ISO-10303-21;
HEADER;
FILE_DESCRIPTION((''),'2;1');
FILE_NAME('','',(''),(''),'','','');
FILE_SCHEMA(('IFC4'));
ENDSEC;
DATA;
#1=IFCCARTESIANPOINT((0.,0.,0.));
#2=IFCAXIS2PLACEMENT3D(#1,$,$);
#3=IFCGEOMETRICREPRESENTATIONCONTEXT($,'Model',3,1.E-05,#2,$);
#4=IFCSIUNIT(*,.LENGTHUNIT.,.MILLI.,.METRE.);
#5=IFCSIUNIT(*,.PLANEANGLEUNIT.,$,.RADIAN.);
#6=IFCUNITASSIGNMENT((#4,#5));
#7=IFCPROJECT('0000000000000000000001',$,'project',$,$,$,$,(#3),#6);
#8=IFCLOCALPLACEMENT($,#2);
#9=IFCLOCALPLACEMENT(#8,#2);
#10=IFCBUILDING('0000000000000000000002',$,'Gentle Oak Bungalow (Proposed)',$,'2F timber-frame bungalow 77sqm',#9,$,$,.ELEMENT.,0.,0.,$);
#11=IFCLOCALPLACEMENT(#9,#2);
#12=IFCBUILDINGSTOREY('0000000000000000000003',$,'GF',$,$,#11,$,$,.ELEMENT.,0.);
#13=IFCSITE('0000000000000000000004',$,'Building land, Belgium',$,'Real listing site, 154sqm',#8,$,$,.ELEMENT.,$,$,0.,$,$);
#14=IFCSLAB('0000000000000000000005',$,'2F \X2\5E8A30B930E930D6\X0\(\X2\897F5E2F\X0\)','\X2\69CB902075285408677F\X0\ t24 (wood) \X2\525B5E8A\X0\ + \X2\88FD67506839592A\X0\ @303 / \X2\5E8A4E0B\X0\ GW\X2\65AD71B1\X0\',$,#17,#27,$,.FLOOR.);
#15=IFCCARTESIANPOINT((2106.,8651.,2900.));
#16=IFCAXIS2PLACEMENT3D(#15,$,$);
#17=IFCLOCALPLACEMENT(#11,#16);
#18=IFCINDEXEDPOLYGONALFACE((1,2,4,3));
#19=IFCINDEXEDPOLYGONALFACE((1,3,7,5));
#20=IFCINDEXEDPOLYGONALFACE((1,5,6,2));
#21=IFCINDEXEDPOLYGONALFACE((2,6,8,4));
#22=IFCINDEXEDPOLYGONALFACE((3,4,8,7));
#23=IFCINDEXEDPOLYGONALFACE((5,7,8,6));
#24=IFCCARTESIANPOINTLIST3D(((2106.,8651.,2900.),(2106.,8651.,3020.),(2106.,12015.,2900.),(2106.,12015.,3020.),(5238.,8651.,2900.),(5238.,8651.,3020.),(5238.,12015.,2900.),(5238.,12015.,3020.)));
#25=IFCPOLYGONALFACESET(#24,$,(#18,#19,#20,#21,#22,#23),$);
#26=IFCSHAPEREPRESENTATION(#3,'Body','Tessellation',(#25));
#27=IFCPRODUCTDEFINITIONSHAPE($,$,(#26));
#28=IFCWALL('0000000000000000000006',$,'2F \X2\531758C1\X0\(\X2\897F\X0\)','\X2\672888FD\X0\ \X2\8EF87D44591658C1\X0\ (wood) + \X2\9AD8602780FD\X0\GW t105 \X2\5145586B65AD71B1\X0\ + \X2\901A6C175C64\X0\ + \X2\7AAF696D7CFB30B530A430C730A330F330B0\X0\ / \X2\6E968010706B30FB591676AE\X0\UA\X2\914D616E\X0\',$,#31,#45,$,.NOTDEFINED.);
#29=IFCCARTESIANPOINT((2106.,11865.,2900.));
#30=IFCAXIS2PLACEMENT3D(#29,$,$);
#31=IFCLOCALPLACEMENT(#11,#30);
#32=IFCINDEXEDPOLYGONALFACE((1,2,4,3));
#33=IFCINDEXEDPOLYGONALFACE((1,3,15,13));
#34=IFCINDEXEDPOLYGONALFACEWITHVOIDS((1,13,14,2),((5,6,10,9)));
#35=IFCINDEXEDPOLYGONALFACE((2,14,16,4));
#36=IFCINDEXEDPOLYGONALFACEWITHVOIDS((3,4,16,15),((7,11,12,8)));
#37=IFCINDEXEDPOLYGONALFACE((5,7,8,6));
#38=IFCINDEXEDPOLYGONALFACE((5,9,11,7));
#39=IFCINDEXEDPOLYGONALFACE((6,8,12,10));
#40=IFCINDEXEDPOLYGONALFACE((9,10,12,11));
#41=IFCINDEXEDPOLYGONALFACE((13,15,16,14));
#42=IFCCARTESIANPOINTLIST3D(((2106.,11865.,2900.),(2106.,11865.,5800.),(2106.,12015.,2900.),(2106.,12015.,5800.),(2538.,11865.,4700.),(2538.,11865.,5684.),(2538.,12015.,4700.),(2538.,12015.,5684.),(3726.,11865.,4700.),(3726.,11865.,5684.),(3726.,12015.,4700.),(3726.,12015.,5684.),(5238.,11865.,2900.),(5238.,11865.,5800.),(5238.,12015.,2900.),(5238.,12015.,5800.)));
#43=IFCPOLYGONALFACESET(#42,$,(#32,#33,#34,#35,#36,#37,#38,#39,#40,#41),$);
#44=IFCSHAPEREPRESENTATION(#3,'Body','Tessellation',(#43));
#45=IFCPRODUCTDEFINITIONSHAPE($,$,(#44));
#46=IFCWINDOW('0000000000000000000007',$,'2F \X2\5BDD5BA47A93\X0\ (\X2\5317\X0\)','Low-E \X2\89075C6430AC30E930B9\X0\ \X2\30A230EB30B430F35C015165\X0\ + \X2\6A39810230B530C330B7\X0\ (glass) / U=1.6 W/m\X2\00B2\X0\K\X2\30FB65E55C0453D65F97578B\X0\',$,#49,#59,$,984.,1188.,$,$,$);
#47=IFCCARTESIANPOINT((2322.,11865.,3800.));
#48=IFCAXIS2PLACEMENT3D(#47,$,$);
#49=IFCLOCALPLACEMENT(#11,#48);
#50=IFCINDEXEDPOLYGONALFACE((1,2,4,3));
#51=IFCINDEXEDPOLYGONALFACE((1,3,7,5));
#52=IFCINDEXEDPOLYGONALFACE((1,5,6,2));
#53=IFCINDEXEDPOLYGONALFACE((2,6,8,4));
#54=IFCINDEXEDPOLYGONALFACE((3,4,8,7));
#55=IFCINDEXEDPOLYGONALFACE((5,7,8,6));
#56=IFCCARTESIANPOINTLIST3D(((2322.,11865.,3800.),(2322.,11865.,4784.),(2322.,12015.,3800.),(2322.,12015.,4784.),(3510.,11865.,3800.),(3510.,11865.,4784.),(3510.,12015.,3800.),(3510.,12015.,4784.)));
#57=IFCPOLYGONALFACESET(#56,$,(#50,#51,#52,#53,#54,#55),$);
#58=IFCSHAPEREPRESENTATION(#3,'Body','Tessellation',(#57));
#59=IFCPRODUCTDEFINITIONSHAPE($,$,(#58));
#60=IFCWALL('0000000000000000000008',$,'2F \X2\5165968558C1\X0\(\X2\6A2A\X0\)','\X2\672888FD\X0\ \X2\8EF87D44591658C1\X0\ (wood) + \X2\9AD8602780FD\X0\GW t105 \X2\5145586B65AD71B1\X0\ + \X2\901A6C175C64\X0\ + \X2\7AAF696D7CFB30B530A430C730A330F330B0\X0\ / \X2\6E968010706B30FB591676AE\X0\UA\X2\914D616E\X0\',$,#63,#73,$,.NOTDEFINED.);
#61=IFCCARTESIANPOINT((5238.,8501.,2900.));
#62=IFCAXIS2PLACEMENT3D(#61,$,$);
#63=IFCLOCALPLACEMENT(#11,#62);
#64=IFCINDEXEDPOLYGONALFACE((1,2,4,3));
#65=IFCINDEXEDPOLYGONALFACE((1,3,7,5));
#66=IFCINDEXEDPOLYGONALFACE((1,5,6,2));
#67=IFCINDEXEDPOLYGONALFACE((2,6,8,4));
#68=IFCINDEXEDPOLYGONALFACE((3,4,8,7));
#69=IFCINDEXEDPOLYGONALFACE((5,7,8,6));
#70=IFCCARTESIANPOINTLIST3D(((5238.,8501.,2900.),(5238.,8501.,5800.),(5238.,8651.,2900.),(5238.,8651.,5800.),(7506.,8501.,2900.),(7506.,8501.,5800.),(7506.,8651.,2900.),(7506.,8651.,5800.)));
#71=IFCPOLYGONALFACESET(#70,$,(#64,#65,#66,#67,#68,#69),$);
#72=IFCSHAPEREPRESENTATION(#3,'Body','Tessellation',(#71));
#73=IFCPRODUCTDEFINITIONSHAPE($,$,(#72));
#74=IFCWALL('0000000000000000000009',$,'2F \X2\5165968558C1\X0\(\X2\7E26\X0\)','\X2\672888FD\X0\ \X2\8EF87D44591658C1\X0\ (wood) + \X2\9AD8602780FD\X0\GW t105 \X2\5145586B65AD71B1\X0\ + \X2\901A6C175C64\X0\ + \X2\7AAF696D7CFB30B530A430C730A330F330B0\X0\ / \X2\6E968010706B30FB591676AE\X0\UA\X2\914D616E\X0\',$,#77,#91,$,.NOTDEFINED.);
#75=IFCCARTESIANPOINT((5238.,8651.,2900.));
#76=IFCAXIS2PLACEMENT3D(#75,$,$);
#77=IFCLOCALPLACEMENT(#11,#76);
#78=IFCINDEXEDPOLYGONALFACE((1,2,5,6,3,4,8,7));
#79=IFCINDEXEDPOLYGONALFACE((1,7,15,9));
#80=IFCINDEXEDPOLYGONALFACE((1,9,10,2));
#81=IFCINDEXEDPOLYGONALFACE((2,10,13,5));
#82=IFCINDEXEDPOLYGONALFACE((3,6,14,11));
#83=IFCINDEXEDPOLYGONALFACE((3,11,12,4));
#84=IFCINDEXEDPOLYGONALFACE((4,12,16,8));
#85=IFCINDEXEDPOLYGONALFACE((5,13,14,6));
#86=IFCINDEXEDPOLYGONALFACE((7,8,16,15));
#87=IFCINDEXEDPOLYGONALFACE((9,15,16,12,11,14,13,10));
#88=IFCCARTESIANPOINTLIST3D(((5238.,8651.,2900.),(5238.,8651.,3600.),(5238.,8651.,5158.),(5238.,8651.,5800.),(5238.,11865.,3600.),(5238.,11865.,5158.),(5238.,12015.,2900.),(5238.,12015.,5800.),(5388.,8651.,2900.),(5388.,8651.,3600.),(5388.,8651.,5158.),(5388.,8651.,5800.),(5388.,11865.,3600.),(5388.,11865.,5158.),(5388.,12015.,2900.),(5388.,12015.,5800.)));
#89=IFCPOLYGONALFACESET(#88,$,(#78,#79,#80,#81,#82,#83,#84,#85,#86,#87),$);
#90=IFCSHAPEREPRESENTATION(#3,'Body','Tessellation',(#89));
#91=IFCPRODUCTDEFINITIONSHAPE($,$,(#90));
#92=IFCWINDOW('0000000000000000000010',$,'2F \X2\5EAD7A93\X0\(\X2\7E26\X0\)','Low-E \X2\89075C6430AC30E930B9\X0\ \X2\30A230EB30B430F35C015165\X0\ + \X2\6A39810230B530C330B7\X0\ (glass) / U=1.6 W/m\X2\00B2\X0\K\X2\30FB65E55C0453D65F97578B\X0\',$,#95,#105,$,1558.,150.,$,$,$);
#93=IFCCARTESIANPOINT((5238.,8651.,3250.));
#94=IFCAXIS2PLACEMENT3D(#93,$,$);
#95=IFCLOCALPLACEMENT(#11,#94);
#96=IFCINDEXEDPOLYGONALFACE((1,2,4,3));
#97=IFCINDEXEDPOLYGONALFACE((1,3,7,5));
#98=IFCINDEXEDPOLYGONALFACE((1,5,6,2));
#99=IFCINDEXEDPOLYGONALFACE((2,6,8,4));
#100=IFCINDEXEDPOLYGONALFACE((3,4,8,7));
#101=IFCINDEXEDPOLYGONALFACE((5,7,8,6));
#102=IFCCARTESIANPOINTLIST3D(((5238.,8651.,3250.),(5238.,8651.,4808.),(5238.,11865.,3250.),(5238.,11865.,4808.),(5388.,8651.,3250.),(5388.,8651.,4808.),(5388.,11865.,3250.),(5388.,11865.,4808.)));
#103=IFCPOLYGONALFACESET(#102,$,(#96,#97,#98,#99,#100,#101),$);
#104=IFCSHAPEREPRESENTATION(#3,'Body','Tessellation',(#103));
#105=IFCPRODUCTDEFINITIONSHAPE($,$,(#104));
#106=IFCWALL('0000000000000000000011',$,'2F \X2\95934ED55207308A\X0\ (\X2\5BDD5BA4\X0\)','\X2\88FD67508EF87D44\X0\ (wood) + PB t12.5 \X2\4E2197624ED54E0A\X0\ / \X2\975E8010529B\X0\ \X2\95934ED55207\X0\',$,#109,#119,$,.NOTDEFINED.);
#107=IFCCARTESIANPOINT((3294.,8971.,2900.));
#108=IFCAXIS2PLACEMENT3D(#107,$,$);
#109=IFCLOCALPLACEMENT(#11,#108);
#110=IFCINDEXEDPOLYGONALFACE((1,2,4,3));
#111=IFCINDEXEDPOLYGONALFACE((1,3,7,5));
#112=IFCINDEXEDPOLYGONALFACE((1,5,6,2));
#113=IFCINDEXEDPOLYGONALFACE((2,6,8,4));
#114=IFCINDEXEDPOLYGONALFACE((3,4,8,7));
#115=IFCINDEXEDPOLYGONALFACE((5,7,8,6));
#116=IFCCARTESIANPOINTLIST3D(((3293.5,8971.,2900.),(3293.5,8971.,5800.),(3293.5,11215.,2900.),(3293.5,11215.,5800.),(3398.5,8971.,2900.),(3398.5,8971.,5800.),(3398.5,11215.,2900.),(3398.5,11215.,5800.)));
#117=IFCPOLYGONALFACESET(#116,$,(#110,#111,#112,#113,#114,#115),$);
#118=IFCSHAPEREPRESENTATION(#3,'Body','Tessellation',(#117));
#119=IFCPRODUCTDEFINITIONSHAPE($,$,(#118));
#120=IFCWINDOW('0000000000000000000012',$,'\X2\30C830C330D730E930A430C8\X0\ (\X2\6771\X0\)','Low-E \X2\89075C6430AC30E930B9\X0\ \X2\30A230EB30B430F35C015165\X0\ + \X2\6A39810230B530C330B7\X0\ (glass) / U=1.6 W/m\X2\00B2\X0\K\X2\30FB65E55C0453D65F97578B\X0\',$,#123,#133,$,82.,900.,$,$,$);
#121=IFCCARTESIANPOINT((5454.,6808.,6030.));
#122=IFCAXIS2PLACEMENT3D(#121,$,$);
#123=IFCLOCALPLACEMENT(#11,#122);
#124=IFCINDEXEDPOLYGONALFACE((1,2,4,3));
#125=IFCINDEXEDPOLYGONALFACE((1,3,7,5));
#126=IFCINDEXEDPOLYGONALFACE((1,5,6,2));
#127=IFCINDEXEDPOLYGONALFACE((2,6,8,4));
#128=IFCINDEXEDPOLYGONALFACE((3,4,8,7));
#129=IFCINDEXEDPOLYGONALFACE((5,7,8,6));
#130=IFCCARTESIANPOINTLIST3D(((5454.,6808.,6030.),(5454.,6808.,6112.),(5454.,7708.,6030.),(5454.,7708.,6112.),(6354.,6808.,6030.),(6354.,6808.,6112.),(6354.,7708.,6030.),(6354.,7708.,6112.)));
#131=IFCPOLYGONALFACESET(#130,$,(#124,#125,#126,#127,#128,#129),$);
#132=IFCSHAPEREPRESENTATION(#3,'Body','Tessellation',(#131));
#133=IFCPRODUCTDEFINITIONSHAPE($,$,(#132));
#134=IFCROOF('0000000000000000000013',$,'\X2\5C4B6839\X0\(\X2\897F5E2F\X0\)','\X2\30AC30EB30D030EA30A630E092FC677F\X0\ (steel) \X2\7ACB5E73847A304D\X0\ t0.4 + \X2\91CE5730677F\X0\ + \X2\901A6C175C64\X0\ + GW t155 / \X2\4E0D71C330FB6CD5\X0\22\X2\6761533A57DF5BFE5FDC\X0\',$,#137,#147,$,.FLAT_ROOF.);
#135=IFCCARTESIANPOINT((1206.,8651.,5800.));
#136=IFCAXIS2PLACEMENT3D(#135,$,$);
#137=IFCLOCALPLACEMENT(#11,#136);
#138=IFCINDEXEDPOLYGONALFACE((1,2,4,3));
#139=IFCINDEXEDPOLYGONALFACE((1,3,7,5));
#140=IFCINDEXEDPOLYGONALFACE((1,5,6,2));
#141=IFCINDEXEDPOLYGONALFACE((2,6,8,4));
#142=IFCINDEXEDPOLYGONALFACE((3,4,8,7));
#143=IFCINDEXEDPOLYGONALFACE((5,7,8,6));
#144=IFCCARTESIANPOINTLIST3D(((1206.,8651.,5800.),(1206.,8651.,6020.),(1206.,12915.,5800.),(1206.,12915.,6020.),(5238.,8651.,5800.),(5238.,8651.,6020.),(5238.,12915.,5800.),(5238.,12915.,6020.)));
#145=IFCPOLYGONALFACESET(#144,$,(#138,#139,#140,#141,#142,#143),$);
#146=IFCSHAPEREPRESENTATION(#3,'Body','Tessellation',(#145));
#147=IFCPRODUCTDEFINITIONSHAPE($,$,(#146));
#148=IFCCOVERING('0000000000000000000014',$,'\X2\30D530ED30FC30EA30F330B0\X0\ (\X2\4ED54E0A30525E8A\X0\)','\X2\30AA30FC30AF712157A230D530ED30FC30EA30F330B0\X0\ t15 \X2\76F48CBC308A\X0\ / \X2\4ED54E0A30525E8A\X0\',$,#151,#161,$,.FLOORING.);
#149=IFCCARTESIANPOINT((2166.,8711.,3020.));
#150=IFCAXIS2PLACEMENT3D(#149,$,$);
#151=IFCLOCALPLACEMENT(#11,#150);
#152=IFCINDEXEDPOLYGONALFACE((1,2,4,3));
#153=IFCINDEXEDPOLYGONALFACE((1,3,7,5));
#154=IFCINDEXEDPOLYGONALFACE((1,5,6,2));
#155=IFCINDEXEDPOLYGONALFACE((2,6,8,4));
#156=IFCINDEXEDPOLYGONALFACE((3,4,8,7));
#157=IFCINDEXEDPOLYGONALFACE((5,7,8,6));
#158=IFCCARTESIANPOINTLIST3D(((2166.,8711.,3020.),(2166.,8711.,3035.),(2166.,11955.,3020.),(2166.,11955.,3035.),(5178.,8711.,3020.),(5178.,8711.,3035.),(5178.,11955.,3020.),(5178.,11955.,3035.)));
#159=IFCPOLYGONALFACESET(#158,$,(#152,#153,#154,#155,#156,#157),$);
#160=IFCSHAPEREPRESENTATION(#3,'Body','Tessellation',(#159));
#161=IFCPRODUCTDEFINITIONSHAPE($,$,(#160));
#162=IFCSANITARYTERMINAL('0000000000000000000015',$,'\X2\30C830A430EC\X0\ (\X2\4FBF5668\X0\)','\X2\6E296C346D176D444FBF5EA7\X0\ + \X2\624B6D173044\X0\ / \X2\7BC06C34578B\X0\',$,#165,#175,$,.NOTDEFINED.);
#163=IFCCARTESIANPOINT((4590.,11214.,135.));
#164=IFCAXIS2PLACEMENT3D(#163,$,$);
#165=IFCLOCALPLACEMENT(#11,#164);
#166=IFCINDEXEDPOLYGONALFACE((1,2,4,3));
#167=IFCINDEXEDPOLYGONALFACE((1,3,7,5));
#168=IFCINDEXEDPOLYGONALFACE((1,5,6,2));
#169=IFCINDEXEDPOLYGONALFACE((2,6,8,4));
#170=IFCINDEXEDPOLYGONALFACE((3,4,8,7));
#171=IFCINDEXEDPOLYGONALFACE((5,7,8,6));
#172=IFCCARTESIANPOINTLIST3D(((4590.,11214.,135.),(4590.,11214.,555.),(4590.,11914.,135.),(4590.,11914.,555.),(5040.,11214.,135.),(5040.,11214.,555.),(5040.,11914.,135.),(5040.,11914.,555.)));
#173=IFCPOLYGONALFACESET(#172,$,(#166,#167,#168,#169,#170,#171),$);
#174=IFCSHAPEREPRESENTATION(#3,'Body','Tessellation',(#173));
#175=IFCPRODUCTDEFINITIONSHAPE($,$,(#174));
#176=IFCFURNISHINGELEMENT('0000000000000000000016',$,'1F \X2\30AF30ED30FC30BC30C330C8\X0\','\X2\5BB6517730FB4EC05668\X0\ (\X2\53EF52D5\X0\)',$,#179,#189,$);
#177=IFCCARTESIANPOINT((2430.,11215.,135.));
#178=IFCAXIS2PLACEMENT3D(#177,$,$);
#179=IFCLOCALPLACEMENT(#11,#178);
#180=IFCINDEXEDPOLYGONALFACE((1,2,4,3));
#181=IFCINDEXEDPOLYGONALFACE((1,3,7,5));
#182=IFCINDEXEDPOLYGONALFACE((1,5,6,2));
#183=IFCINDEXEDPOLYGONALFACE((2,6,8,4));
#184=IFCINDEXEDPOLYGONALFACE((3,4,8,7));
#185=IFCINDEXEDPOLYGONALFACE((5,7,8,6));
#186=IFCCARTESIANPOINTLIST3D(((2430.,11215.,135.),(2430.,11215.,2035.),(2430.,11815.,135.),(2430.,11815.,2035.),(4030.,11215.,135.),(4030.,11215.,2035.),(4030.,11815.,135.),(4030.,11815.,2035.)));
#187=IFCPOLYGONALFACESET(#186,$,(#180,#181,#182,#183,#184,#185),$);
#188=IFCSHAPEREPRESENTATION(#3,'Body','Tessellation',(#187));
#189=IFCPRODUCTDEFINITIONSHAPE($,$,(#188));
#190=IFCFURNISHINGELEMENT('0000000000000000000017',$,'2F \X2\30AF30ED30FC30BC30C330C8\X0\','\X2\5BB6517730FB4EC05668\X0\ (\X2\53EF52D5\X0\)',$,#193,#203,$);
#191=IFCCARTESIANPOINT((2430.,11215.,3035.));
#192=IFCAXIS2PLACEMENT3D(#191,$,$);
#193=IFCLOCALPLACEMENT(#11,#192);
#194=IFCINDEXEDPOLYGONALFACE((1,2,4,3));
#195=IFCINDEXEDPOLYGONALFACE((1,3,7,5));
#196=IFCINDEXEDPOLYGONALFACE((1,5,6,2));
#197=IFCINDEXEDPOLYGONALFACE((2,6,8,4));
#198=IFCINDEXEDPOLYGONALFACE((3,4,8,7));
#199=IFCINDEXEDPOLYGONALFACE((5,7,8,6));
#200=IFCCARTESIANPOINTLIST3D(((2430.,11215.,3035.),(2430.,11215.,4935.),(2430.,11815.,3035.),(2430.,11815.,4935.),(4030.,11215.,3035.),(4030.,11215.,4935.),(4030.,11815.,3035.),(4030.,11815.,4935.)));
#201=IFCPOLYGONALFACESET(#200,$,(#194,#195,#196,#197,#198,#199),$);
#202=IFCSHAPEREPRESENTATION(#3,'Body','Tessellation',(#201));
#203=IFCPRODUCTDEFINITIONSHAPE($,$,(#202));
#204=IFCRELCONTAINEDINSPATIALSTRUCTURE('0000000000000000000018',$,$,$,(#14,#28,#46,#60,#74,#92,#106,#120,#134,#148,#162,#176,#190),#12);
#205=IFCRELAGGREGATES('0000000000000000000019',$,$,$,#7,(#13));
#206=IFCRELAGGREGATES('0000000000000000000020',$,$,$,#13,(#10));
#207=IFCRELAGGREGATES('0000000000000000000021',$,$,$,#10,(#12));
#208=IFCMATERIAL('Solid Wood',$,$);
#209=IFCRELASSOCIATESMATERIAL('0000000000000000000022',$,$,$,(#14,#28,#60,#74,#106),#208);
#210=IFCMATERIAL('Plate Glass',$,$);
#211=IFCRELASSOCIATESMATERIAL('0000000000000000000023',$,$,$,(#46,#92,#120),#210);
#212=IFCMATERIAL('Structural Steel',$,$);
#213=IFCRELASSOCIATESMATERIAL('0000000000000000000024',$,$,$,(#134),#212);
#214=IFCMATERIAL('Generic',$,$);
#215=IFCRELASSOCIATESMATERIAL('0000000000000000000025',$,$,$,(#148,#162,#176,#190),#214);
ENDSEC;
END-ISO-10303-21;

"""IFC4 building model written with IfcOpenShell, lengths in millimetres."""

from ifc_helpers import new_model, si_unit, frame, frame_2d, origin, place, context, project, spatial, rectangle, extrude, material, element, fill, save


model = new_model("IFC4")

# Units and contexts
model_context = context("Model", 3, precision=1e-05, world=origin())
ifc_project = project(units=[si_unit("LENGTHUNIT", "METRE", prefix="MILLI"), si_unit("PLANEANGLEUNIT", "RADIAN")], contexts=[model_context])

# Site, building, storey
site_placement = place(None, origin())
site = spatial("IfcSite", under=ifc_project, at=site_placement, Name="Building land, Belgium", ObjectType="Real listing site, 154sqm", CompositionType="ELEMENT", RefElevation=0.0)
building_placement = place(site_placement, origin())
building = spatial("IfcBuilding", under=site, at=building_placement, Name="Gentle Oak Bungalow (Proposed)", ObjectType="2F timber-frame bungalow 77sqm", CompositionType="ELEMENT", ElevationOfRefHeight=0.0, ElevationOfTerrain=0.0)
storey_placement = place(building_placement, origin())
storey = spatial("IfcBuildingStorey", under=building, at=storey_placement, Name="GF", CompositionType="ELEMENT", Elevation=0.0)

# Slab
ifc_material_1 = material(Name="Solid Wood")
slab_placement = place(storey_placement, frame((2106.0, 8651.0, 2900.0)))
element("IfcSlab", 1, at=slab_placement, inside=storey, material=ifc_material_1, Name="2F 床スラブ(西帯)", Description="構造用合板 t24 (wood) 剛床 + 製材根太 @303 / 床下 GW断熱", PredefinedType="FLOOR", context=model_context, shape_type="SweptSolid", body=[
    extrude(rectangle(XDim=3132.0, YDim=3364.0, at=frame_2d((1566.0, 1682.0))), frame((2106.0, 8651.0, 2900.0)), (0.0, 0.0, 1.0), 120.0),
])

# Wall, opening, window
wall_1_placement = place(storey_placement, frame((2106.0, 11865.0, 2900.0)))
wall_1 = element("IfcWall", 2, at=wall_1_placement, inside=storey, material=ifc_material_1, Name="2F 北壁(西)", Description="木製 軸組外壁 (wood) + 高性能GW t105 充填断熱 + 通気層 + 窯業系サイディング / 準耐火・外皮UA配慮", PredefinedType="NOTDEFINED", context=model_context, shape_type="SweptSolid", body=[
    extrude(rectangle(XDim=3132.0, YDim=150.0, at=frame_2d((1566.0, 75.0))), frame((2106.0, 11865.0, 2900.0)), (0.0, 0.0, 1.0), 2900.0),
])
opening_1_placement = place(storey_placement, frame((2322.0, 11865.0, 3800.0)))
opening_1 = element("IfcOpeningElement", 3, at=opening_1_placement, cuts=wall_1, PredefinedType="NOTDEFINED", context=model_context, shape_type="SweptSolid", body=[
    extrude(rectangle(XDim=1188.0, YDim=150.0, at=frame_2d((594.0, 75.0))), frame((2322.0, 11865.0, 3800.0)), (0.0, 0.0, 1.0), 984.0),
])
ifc_material_2 = material(Name="Plate Glass")
window_1_placement = place(storey_placement, frame((2322.0, 11865.0, 3800.0)))
window_1 = element("IfcWindow", 4, at=window_1_placement, inside=storey, material=ifc_material_2, Name="2F 寝室窓 (北)", Description="Low-E 複層ガラス アルゴン封入 + 樹脂サッシ (glass) / U=1.6 W/m²K・日射取得型", OverallHeight=984.0, OverallWidth=1188.0, context=model_context, shape_type="SweptSolid", body=[
    extrude(rectangle(XDim=1188.0, YDim=150.0, at=frame_2d((594.0, 75.0))), frame((2322.0, 11865.0, 3800.0)), (0.0, 0.0, 1.0), 984.0),
])
fill(opening_1, window_1)

# Wall
wall_2_placement = place(storey_placement, frame((5238.0, 8501.0, 2900.0)))
element("IfcWall", 5, at=wall_2_placement, inside=storey, material=ifc_material_1, Name="2F 入隅壁(横)", Description="木製 軸組外壁 (wood) + 高性能GW t105 充填断熱 + 通気層 + 窯業系サイディング / 準耐火・外皮UA配慮", PredefinedType="NOTDEFINED", context=model_context, shape_type="SweptSolid", body=[
    extrude(rectangle(XDim=2268.0, YDim=150.0, at=frame_2d((1134.0, 75.0))), frame((5238.0, 8501.0, 2900.0)), (0.0, 0.0, 1.0), 2900.0),
])

# Wall, opening, window
wall_3_placement = place(storey_placement, frame((5238.0, 8651.0, 2900.0)))
wall_3 = element("IfcWall", 6, at=wall_3_placement, inside=storey, material=ifc_material_1, Name="2F 入隅壁(縦)", Description="木製 軸組外壁 (wood) + 高性能GW t105 充填断熱 + 通気層 + 窯業系サイディング / 準耐火・外皮UA配慮", PredefinedType="NOTDEFINED", context=model_context, shape_type="SweptSolid", body=[
    extrude(rectangle(XDim=150.0, YDim=3364.0, at=frame_2d((75.0, 1682.0))), frame((5238.0, 8651.0, 2900.0)), (0.0, 0.0, 1.0), 2900.0),
])
opening_2_placement = place(storey_placement, frame((5238.0, 8651.0, 3250.0)))
opening_2 = element("IfcOpeningElement", 7, at=opening_2_placement, cuts=wall_3, PredefinedType="NOTDEFINED", context=model_context, shape_type="SweptSolid", body=[
    extrude(rectangle(XDim=150.0, YDim=3214.0, at=frame_2d((75.0, 1607.0))), frame((5238.0, 8651.0, 3250.0)), (0.0, 0.0, 1.0), 1558.0),
])
window_2_placement = place(storey_placement, frame((5238.0, 8651.0, 3250.0)))
window_2 = element("IfcWindow", 8, at=window_2_placement, inside=storey, material=ifc_material_2, Name="2F 庭窓(縦)", Description="Low-E 複層ガラス アルゴン封入 + 樹脂サッシ (glass) / U=1.6 W/m²K・日射取得型", OverallHeight=1558.0, OverallWidth=150.0, context=model_context, shape_type="SweptSolid", body=[
    extrude(rectangle(XDim=150.0, YDim=3214.0, at=frame_2d((75.0, 1607.0))), frame((5238.0, 8651.0, 3250.0)), (0.0, 0.0, 1.0), 1558.0),
])
fill(opening_2, window_2)

# Wall
wall_4_placement = place(storey_placement, frame((3294.0, 8971.0, 2900.0)))
element("IfcWall", 9, at=wall_4_placement, inside=storey, material=ifc_material_1, Name="2F 間仕切り (寝室)", Description="製材軸組 (wood) + PB t12.5 両面仕上 / 非耐力 間仕切", PredefinedType="NOTDEFINED", context=model_context, shape_type="SweptSolid", body=[
    extrude(rectangle(XDim=105.0, YDim=2244.0, at=frame_2d((52.0, 1122.0))), frame((3294.0, 8971.0, 2900.0)), (0.0, 0.0, 1.0), 2900.0),
])

# Window
window_3_placement = place(storey_placement, frame((5454.0, 6808.0, 6030.0)))
element("IfcWindow", 10, at=window_3_placement, inside=storey, material=ifc_material_2, Name="トップライト (東)", Description="Low-E 複層ガラス アルゴン封入 + 樹脂サッシ (glass) / U=1.6 W/m²K・日射取得型", OverallHeight=82.0, OverallWidth=900.0, context=model_context, shape_type="SweptSolid", body=[
    extrude(rectangle(XDim=900.0, YDim=900.0, at=frame_2d((450.0, 450.0))), frame((5454.0, 6808.0, 6030.0)), (0.0, 0.0, 1.0), 82.0),
])

# Roof
ifc_material_3 = material(Name="Structural Steel")
for number, where, name in (
    (11, (1206.0, 8651.0, 5800.0), "屋根(西帯)"),
):
    element("IfcRoof", number, at=place(storey_placement, frame(where)), inside=storey, material=ifc_material_3, Name=name, Description="ガルバリウム鋼板 (steel) 立平葺き t0.4 + 野地板 + 通気層 + GW t155 / 不燃・法22条区域対応", PredefinedType="FLAT_ROOF", context=model_context, shape_type="SweptSolid", body=[
        extrude(rectangle(XDim=4032.0, YDim=4264.0, at=frame_2d((2016.0, 2132.0))), frame((1206.0, 8651.0, 5800.0)), (0.0, 0.0, 1.0), 220.0),
    ])

# Covering
ifc_material_4 = material(Name="Generic")
covering_placement = place(storey_placement, frame((2166.0, 8711.0, 3020.0)))
element("IfcCovering", 12, at=covering_placement, inside=storey, material=ifc_material_4, Name="フローリング (仕上げ床)", Description="オーク無垢フローリング t15 直貼り / 仕上げ床", PredefinedType="FLOORING", context=model_context, shape_type="SweptSolid", body=[
    extrude(rectangle(XDim=3012.0, YDim=3244.0, at=frame_2d((1506.0, 1622.0))), frame((2166.0, 8711.0, 3020.0)), (0.0, 0.0, 1.0), 15.0),
])

# Sanitary terminal
sanitary_terminal_placement = place(storey_placement, frame((4590.0, 11214.0, 135.0)))
element("IfcSanitaryTerminal", 13, at=sanitary_terminal_placement, inside=storey, material=ifc_material_4, Name="トイレ (便器)", Description="温水洗浄便座 + 手洗い / 節水型", PredefinedType="NOTDEFINED", context=model_context, shape_type="SweptSolid", body=[
    extrude(rectangle(XDim=450.0, YDim=700.0, at=frame_2d((225.0, 350.0))), frame((4590.0, 11214.0, 135.0)), (0.0, 0.0, 1.0), 420.0),
])

# Furnishing elements
furnishing_1_placement = place(storey_placement, frame((2430.0, 11215.0, 135.0)))
element("IfcFurnishingElement", 14, at=furnishing_1_placement, inside=storey, material=ifc_material_4, Name="1F クローゼット", Description="家具・什器 (可動)", context=model_context, shape_type="SweptSolid", body=[
    extrude(rectangle(XDim=1600.0, YDim=600.0, at=frame_2d((800.0, 300.0))), frame((2430.0, 11215.0, 135.0)), (0.0, 0.0, 1.0), 1900.0),
])
furnishing_2_placement = place(storey_placement, frame((2430.0, 11215.0, 3035.0)))
element("IfcFurnishingElement", 15, at=furnishing_2_placement, inside=storey, material=ifc_material_4, Name="2F クローゼット", Description="家具・什器 (可動)", context=model_context, shape_type="SweptSolid", body=[
    extrude(rectangle(XDim=1600.0, YDim=600.0, at=frame_2d((800.0, 300.0))), frame((2430.0, 11215.0, 3035.0)), (0.0, 0.0, 1.0), 1900.0),
])

save(model, "model.ifc")
